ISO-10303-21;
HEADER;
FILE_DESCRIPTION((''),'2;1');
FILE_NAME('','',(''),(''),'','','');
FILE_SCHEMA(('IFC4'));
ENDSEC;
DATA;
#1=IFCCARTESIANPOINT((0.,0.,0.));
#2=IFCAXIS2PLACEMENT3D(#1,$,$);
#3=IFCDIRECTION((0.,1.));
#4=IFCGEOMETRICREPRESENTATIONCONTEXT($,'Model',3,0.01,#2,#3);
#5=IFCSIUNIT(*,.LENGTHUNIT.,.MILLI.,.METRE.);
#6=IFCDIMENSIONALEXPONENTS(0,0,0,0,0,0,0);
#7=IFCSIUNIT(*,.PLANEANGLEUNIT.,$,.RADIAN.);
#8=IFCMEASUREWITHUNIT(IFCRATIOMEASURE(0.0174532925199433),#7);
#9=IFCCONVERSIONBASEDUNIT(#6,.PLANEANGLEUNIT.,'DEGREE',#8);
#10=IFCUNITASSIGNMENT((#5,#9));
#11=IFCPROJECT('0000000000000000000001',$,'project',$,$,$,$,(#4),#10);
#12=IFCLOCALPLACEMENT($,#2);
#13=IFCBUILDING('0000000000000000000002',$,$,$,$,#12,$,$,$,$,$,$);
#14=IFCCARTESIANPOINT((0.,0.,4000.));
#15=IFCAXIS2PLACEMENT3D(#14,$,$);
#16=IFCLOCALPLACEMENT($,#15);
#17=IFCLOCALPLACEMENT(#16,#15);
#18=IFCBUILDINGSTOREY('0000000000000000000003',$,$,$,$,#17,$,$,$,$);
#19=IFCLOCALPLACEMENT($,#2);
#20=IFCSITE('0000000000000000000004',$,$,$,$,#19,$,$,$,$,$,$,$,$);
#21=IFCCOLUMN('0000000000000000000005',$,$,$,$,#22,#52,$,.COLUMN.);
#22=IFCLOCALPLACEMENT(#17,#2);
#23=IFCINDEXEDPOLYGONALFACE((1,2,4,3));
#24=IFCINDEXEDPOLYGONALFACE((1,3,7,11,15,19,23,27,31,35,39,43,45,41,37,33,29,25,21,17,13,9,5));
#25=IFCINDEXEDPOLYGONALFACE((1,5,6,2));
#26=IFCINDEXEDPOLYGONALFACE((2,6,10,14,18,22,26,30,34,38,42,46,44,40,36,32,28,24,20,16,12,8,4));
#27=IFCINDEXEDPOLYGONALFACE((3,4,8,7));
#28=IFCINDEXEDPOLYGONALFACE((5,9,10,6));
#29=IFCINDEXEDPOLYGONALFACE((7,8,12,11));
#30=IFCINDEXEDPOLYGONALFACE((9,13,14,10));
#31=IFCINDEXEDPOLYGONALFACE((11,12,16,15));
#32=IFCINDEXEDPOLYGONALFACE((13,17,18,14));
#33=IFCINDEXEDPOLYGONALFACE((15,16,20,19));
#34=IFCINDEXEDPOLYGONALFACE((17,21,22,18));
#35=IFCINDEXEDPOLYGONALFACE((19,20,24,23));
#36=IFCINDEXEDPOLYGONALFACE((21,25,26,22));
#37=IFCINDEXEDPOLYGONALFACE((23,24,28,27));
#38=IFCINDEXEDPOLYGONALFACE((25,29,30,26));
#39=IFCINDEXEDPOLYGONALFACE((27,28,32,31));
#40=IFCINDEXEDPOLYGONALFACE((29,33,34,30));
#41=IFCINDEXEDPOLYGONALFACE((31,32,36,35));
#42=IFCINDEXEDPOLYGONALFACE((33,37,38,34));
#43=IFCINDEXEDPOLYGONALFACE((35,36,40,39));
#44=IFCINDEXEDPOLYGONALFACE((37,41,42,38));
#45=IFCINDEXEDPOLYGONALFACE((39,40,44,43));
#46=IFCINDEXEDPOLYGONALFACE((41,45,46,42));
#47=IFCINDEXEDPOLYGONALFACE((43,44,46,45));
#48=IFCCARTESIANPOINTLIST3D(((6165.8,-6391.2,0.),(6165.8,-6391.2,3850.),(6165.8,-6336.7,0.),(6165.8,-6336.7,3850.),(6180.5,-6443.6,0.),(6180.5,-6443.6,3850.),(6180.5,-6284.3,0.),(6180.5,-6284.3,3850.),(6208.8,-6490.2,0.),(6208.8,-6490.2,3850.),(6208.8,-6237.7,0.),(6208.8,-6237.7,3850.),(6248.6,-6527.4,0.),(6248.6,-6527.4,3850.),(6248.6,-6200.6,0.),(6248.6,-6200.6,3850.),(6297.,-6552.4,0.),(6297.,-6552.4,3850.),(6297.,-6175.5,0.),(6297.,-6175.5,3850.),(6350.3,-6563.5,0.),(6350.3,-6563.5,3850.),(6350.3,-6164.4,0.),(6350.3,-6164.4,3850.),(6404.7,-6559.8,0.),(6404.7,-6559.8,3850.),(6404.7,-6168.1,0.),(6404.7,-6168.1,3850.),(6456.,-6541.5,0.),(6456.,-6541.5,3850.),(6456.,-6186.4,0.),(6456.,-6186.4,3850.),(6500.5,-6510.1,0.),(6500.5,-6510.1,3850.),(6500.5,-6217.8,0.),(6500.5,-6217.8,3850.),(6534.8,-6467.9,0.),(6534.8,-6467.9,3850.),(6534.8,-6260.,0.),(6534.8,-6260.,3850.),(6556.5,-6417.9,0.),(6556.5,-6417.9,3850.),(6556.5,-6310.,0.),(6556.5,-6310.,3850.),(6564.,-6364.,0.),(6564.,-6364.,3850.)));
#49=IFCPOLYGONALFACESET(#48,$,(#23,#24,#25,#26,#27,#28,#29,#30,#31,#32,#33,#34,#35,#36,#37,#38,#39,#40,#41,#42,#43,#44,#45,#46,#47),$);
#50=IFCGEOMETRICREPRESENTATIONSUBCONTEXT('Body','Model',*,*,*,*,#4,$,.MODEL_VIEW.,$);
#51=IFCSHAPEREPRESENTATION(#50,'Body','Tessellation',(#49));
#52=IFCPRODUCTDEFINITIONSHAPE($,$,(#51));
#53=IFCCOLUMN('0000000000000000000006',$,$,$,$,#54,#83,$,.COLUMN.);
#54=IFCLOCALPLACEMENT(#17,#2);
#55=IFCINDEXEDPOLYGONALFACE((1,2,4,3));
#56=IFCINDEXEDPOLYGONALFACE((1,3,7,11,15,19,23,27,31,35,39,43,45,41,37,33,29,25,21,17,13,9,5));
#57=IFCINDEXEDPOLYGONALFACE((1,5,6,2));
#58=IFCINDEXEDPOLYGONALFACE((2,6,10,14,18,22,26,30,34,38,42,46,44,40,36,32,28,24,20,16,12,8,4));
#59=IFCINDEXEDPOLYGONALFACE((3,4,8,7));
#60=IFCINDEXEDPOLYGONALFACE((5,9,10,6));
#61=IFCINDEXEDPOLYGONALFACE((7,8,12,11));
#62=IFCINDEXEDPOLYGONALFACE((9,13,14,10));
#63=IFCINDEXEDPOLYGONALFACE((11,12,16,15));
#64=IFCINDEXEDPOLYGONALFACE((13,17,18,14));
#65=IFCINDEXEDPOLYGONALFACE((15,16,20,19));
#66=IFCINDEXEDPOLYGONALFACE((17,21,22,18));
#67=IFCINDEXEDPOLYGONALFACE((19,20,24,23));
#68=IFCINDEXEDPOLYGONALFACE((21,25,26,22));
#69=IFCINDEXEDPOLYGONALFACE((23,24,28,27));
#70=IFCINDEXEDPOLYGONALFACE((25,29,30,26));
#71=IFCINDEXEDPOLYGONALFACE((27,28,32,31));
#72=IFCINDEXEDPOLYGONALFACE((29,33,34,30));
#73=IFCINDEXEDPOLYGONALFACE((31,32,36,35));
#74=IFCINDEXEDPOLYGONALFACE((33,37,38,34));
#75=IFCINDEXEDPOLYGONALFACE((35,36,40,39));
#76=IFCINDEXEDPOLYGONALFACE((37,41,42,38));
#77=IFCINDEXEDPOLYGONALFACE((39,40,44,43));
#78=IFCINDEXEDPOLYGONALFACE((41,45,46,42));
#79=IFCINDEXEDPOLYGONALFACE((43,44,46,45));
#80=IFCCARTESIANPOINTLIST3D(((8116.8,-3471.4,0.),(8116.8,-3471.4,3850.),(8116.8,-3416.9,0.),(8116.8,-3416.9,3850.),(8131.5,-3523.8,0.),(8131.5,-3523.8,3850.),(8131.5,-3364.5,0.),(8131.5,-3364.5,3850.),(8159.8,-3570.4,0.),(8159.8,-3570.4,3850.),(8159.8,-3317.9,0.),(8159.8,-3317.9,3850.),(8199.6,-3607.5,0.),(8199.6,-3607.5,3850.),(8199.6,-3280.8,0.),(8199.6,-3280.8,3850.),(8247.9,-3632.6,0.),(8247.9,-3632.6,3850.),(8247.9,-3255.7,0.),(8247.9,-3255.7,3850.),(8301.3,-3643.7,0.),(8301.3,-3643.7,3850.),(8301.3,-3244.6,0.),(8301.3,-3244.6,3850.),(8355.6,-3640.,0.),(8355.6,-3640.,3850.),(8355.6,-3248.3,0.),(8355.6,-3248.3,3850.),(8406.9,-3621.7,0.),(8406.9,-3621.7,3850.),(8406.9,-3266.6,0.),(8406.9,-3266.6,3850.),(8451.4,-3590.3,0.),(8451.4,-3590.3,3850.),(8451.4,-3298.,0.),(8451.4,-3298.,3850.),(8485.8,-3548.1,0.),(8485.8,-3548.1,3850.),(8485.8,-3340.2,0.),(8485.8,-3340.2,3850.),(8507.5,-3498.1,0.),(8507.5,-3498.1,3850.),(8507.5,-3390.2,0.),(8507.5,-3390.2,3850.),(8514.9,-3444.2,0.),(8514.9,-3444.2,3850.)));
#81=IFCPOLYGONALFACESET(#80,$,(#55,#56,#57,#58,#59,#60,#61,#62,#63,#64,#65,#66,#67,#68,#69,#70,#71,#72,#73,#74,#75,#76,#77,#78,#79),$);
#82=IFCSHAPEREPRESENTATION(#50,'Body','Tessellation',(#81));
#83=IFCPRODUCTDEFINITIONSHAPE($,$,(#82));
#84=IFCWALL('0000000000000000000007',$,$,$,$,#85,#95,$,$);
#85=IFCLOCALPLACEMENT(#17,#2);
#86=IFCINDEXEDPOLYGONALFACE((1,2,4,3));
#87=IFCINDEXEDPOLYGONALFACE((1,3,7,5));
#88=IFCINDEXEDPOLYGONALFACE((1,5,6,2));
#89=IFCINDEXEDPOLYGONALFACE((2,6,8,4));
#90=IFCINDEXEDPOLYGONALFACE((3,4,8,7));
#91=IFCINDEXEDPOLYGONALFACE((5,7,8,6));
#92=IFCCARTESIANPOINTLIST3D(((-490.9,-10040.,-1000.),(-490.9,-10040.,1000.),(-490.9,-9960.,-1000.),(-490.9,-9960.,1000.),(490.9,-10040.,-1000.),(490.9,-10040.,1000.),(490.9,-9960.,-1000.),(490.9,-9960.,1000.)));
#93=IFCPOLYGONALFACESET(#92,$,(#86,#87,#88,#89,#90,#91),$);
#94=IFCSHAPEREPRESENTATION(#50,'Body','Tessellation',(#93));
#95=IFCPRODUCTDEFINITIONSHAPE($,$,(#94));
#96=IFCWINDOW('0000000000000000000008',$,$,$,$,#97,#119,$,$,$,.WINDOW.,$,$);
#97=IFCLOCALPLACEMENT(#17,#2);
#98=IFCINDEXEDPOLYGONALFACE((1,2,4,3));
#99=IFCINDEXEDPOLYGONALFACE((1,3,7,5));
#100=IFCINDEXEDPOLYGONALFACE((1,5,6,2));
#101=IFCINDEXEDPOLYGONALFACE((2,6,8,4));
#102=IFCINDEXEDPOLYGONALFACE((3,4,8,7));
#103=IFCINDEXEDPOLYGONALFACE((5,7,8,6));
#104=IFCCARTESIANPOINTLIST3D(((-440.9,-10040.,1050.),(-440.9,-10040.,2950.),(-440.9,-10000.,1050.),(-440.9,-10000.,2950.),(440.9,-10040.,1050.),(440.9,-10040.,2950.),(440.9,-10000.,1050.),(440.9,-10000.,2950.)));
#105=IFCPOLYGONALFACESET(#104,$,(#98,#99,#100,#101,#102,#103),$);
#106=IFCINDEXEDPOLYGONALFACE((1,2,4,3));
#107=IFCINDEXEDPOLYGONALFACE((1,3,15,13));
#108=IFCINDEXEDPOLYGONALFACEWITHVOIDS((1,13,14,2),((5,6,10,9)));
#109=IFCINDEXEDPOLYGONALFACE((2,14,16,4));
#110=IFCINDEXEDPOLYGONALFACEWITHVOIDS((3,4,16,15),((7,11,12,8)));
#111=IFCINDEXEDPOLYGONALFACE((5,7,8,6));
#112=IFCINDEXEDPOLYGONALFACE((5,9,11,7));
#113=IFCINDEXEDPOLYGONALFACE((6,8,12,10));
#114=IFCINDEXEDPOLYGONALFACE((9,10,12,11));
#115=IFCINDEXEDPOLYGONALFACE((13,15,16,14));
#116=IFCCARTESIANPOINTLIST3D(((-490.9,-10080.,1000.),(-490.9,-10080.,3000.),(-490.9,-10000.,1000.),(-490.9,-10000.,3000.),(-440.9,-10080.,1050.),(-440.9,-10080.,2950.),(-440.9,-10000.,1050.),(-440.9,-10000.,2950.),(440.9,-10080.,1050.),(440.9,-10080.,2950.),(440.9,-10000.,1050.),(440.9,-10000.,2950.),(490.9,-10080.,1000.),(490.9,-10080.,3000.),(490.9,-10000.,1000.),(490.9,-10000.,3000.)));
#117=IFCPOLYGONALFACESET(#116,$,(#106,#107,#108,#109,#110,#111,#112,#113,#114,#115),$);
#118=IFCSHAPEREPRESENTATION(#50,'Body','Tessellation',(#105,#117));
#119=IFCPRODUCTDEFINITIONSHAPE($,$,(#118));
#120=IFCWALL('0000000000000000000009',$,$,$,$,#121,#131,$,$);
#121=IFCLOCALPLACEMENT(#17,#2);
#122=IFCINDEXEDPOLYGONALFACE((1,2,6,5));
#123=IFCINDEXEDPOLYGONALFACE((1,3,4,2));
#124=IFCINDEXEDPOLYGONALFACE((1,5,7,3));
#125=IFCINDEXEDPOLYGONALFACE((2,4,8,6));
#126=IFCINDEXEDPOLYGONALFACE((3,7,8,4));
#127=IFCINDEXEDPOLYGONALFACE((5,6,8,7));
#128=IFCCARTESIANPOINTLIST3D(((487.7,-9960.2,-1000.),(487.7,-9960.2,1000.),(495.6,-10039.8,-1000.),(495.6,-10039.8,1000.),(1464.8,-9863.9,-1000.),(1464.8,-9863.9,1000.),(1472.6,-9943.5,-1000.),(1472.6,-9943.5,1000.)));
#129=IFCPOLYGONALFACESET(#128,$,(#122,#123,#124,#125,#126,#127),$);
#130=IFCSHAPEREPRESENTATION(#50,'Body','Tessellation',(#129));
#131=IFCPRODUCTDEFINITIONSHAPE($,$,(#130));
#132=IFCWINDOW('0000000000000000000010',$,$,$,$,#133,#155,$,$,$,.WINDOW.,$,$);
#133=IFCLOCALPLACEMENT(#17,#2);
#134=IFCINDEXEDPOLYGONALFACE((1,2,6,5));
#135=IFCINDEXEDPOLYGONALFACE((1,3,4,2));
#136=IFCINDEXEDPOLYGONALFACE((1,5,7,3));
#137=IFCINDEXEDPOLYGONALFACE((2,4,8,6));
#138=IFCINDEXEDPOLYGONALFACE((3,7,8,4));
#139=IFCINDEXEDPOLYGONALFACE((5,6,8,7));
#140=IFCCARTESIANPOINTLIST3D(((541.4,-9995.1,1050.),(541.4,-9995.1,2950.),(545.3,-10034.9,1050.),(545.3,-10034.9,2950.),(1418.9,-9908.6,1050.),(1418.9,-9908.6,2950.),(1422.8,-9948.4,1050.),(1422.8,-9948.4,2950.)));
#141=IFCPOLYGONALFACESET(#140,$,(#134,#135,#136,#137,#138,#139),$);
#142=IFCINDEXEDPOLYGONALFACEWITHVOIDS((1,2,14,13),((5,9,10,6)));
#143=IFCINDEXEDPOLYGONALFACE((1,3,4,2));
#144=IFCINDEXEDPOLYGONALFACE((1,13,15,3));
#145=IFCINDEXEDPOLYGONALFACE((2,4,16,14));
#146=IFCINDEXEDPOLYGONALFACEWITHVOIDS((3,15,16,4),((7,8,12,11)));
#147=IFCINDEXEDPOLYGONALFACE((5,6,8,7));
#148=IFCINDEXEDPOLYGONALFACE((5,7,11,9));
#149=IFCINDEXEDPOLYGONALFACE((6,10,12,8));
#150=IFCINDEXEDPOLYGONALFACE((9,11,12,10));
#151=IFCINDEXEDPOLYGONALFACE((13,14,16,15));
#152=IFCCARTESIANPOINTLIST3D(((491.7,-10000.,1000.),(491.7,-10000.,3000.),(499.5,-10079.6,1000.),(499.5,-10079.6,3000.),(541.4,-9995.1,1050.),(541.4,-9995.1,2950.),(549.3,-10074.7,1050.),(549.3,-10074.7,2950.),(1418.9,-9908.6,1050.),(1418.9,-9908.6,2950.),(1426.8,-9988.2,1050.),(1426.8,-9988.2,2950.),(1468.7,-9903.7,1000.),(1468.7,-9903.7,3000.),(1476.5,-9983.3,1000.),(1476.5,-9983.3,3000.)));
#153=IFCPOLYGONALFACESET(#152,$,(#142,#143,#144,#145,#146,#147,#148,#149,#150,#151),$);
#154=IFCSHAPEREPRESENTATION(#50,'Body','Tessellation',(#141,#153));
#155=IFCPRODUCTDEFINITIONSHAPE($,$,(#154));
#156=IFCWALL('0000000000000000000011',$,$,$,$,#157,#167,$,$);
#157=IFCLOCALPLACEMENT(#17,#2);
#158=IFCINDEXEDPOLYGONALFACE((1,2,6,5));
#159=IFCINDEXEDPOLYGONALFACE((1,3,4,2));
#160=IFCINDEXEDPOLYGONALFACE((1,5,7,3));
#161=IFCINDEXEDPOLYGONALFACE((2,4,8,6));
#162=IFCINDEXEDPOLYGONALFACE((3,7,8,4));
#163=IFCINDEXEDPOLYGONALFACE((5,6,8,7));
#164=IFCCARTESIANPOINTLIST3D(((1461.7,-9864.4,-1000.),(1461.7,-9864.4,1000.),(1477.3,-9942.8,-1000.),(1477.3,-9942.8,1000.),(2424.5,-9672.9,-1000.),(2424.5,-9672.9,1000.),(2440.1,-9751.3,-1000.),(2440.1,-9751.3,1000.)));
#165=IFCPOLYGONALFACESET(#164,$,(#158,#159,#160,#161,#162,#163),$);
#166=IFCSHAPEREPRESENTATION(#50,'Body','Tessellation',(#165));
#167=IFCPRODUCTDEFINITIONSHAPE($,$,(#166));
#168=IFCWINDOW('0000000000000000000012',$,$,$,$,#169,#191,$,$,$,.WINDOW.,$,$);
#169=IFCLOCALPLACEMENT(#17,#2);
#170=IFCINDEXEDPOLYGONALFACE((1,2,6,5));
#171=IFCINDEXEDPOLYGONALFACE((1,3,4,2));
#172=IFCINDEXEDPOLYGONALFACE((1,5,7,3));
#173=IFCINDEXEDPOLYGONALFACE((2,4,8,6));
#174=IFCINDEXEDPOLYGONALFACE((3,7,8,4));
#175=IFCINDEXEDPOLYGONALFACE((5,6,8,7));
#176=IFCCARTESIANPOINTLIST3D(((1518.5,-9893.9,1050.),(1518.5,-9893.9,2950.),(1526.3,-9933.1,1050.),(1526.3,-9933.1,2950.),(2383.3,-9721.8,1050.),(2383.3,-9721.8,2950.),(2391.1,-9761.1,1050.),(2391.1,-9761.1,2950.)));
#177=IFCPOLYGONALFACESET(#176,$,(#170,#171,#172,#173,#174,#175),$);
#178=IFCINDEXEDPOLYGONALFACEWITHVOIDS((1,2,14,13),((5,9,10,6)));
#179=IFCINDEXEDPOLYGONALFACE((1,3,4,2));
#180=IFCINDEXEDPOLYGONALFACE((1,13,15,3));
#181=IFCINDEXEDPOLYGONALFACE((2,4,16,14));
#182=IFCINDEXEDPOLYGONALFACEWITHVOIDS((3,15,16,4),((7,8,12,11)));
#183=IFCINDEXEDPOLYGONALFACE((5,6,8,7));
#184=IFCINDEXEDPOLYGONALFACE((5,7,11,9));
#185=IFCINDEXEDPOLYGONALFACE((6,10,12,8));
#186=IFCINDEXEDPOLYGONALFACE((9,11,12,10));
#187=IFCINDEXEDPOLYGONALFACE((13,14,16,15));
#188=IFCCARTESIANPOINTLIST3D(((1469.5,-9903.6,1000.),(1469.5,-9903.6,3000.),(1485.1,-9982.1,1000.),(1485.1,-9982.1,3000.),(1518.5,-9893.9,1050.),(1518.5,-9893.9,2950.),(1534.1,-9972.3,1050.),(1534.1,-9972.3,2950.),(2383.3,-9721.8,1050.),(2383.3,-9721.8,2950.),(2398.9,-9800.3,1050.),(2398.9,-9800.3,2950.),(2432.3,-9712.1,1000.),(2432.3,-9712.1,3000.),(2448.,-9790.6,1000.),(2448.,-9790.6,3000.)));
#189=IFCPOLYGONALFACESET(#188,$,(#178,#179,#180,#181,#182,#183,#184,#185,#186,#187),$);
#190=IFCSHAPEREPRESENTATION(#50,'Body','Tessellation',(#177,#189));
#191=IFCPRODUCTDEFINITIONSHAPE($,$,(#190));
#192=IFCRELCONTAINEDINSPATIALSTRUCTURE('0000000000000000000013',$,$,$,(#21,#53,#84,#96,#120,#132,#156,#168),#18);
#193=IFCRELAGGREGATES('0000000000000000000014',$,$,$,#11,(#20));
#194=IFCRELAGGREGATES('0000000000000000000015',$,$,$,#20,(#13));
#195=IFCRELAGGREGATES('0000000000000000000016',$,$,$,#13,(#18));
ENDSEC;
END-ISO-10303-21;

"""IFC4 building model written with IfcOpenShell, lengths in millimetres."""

from ifc_helpers import new_model, entity, si_unit, converted_unit, direction, frame, origin, origin_2d, place, context, subcontext, project, spatial, rectangle, circle, extrude, element, save


model = new_model("IFC4")

# Units and contexts
model_context = context("Model", 3, precision=0.01, world=origin(), true_north=direction((0.0, 1.0)))
body_context = subcontext(model_context, "Body", "Model", "MODEL_VIEW")
ifc_project = project(units=[si_unit("LENGTHUNIT", "METRE", prefix="MILLI"), converted_unit("PLANEANGLEUNIT", "DEGREE", entity("IfcRatioMeasure", 0.0174532925199433), si_unit("PLANEANGLEUNIT", "RADIAN"), dimensions=[0, 0, 0, 0, 0, 0, 0])], contexts=[model_context])

# Site, building, storey
site_placement = place(None, origin())
site = spatial("IfcSite", under=ifc_project, at=site_placement)
building_placement = place(None, origin())
building = spatial("IfcBuilding", under=site, at=building_placement)
placement = place(None, frame((0.0, 0.0, 4000.0)))
storey_placement = place(placement, frame((0.0, 0.0, 4000.0)))
storey = spatial("IfcBuildingStorey", under=building, at=storey_placement)

# Columns
for number, where in (
    (1, (6364.0, -6364.0, 0.0)),
    (2, (8314.9, -3444.2, 0.0)),
):
    element("IfcColumn", number, at=place(storey_placement, frame(where)), inside=storey, PredefinedType="COLUMN", context=body_context, shape_type="SweptSolid", body=[
        extrude(circle(Radius=200.0, at=origin_2d()), origin(), (0.0, 0.0, 1.0), 3850.0),
    ])

# Wall
wall_1_placement = place(storey_placement, frame((0.0, -10000.0, -1000.0), z_axis=(0.0, 0.0, 1.0), x_axis=(10000.0, 0.000119, 0.0)))
element("IfcWall", 3, at=wall_1_placement, inside=storey, context=body_context, shape_type="SweptSolid", body=[
    extrude(rectangle(XDim=981.7, YDim=80.0, at=origin_2d()), origin(), (0.0, 0.0, 1.0), 2000.0),
])

# Window
cartesian_point_1 = entity("IfcCartesianPoint", [-440.9, -950.0])
shared_polyline = entity("IfcPolyline", [cartesian_point_1, entity("IfcCartesianPoint", [-440.9, 950.0]), entity("IfcCartesianPoint", [-440.9, 950.0]), entity("IfcCartesianPoint", [440.9, 950.0]), entity("IfcCartesianPoint", [440.9, 950.0]), entity("IfcCartesianPoint", [440.9, -950.0]), entity("IfcCartesianPoint", [440.9, -950.0]), entity("IfcCartesianPoint", [-440.9, -950.0]), cartesian_point_1])
window_1_placement = place(storey_placement, frame((0.0, -10000.0, 2000.0), z_axis=(0.0, 0.0, 1.0), x_axis=(10000.0, 0.000119, 0.0)))
cartesian_point_2 = entity("IfcCartesianPoint", [-490.9, -1000.0])
element("IfcWindow", 4, at=window_1_placement, inside=storey, PredefinedType="WINDOW", context=body_context, shape_type="SweptSolid", body=[
    entity("IfcExtrudedAreaSolid", entity("IfcArbitraryClosedProfileDef", "AREA", None, shared_polyline), entity("IfcAxis2Placement3D", entity("IfcCartesianPoint", [0.0, 0.0, 0.0]), entity("IfcDirection", [0.0, -1.0, 0.0]), entity("IfcDirection", [1.0, 0.0, 0.0])), entity("IfcDirection", [0.0, 0.0, 1.0]), 40.0),
    entity("IfcExtrudedAreaSolid", entity("IfcArbitraryProfileDefWithVoids", "AREA", None, entity("IfcPolyline", [cartesian_point_2, entity("IfcCartesianPoint", [-490.9, 1000.0]), entity("IfcCartesianPoint", [-490.9, 1000.0]), entity("IfcCartesianPoint", [490.9, 1000.0]), entity("IfcCartesianPoint", [490.9, 1000.0]), entity("IfcCartesianPoint", [490.9, -1000.0]), entity("IfcCartesianPoint", [490.9, -1000.0]), entity("IfcCartesianPoint", [-490.9, -1000.0]), cartesian_point_2]), [shared_polyline]), entity("IfcAxis2Placement3D", entity("IfcCartesianPoint", [0.0, 0.0, 0.0]), entity("IfcDirection", [0.0, -1.0, 0.0]), entity("IfcDirection", [1.0, 0.0, 0.0])), entity("IfcDirection", [0.0, 0.0, 1.0]), 80.0),
])

# Wall
wall_2_placement = place(storey_placement, frame((980.2, -9951.8, -1000.0), z_axis=(0.0, 0.0, 1.0), x_axis=(9951.84745, 980.169547, 0.0)))
element("IfcWall", 5, at=wall_2_placement, inside=storey, context=body_context, shape_type="SweptSolid", body=[
    extrude(rectangle(XDim=981.7, YDim=80.0, at=origin_2d()), origin(), (0.0, 0.0, 1.0), 2000.0),
])

# Window
window_2_placement = place(storey_placement, frame((980.2, -9951.8, 2000.0), z_axis=(0.0, 0.0, 1.0), x_axis=(9951.84745, 980.169547, 0.0)))
cartesian_point_3 = entity("IfcCartesianPoint", [-490.9, -1000.0])
element("IfcWindow", 6, at=window_2_placement, inside=storey, PredefinedType="WINDOW", context=body_context, shape_type="SweptSolid", body=[
    entity("IfcExtrudedAreaSolid", entity("IfcArbitraryClosedProfileDef", "AREA", None, shared_polyline), entity("IfcAxis2Placement3D", entity("IfcCartesianPoint", [0.0, 0.0, 0.0]), entity("IfcDirection", [0.0, -1.0, 0.0]), entity("IfcDirection", [1.0, 0.0, 0.0])), entity("IfcDirection", [0.0, 0.0, 1.0]), 40.0),
    entity("IfcExtrudedAreaSolid", entity("IfcArbitraryProfileDefWithVoids", "AREA", None, entity("IfcPolyline", [cartesian_point_3, entity("IfcCartesianPoint", [-490.9, 1000.0]), entity("IfcCartesianPoint", [-490.9, 1000.0]), entity("IfcCartesianPoint", [490.9, 1000.0]), entity("IfcCartesianPoint", [490.9, 1000.0]), entity("IfcCartesianPoint", [490.9, -1000.0]), entity("IfcCartesianPoint", [490.9, -1000.0]), entity("IfcCartesianPoint", [-490.9, -1000.0]), cartesian_point_3]), [shared_polyline]), entity("IfcAxis2Placement3D", entity("IfcCartesianPoint", [0.0, 0.0, 0.0]), entity("IfcDirection", [0.0, -1.0, 0.0]), entity("IfcDirection", [1.0, 0.0, 0.0])), entity("IfcDirection", [0.0, 0.0, 1.0]), 80.0),
])

# Wall
wall_3_placement = place(storey_placement, frame((1950.9, -9807.9, -1000.0), z_axis=(0.0, 0.0, 1.0), x_axis=(9807.852625, 1950.904121, 0.0)))
element("IfcWall", 7, at=wall_3_placement, inside=storey, context=body_context, shape_type="SweptSolid", body=[
    extrude(rectangle(XDim=981.7, YDim=80.0, at=origin_2d()), origin(), (0.0, 0.0, 1.0), 2000.0),
])

# Window
window_3_placement = place(storey_placement, frame((1950.9, -9807.9, 2000.0), z_axis=(0.0, 0.0, 1.0), x_axis=(9807.852625, 1950.904121, 0.0)))
cartesian_point_4 = entity("IfcCartesianPoint", [-490.9, -1000.0])
element("IfcWindow", 8, at=window_3_placement, inside=storey, PredefinedType="WINDOW", context=body_context, shape_type="SweptSolid", body=[
    entity("IfcExtrudedAreaSolid", entity("IfcArbitraryClosedProfileDef", "AREA", None, shared_polyline), entity("IfcAxis2Placement3D", entity("IfcCartesianPoint", [0.0, 0.0, 0.0]), entity("IfcDirection", [0.0, -1.0, 0.0]), entity("IfcDirection", [1.0, 0.0, 0.0])), entity("IfcDirection", [0.0, 0.0, 1.0]), 40.0),
    entity("IfcExtrudedAreaSolid", entity("IfcArbitraryProfileDefWithVoids", "AREA", None, entity("IfcPolyline", [cartesian_point_4, entity("IfcCartesianPoint", [-490.9, 1000.0]), entity("IfcCartesianPoint", [-490.9, 1000.0]), entity("IfcCartesianPoint", [490.9, 1000.0]), entity("IfcCartesianPoint", [490.9, 1000.0]), entity("IfcCartesianPoint", [490.9, -1000.0]), entity("IfcCartesianPoint", [490.9, -1000.0]), entity("IfcCartesianPoint", [-490.9, -1000.0]), cartesian_point_4]), [shared_polyline]), entity("IfcAxis2Placement3D", entity("IfcCartesianPoint", [0.0, 0.0, 0.0]), entity("IfcDirection", [0.0, -1.0, 0.0]), entity("IfcDirection", [1.0, 0.0, 0.0])), entity("IfcDirection", [0.0, 0.0, 1.0]), 80.0),
])

save(model, "model.ifc")
